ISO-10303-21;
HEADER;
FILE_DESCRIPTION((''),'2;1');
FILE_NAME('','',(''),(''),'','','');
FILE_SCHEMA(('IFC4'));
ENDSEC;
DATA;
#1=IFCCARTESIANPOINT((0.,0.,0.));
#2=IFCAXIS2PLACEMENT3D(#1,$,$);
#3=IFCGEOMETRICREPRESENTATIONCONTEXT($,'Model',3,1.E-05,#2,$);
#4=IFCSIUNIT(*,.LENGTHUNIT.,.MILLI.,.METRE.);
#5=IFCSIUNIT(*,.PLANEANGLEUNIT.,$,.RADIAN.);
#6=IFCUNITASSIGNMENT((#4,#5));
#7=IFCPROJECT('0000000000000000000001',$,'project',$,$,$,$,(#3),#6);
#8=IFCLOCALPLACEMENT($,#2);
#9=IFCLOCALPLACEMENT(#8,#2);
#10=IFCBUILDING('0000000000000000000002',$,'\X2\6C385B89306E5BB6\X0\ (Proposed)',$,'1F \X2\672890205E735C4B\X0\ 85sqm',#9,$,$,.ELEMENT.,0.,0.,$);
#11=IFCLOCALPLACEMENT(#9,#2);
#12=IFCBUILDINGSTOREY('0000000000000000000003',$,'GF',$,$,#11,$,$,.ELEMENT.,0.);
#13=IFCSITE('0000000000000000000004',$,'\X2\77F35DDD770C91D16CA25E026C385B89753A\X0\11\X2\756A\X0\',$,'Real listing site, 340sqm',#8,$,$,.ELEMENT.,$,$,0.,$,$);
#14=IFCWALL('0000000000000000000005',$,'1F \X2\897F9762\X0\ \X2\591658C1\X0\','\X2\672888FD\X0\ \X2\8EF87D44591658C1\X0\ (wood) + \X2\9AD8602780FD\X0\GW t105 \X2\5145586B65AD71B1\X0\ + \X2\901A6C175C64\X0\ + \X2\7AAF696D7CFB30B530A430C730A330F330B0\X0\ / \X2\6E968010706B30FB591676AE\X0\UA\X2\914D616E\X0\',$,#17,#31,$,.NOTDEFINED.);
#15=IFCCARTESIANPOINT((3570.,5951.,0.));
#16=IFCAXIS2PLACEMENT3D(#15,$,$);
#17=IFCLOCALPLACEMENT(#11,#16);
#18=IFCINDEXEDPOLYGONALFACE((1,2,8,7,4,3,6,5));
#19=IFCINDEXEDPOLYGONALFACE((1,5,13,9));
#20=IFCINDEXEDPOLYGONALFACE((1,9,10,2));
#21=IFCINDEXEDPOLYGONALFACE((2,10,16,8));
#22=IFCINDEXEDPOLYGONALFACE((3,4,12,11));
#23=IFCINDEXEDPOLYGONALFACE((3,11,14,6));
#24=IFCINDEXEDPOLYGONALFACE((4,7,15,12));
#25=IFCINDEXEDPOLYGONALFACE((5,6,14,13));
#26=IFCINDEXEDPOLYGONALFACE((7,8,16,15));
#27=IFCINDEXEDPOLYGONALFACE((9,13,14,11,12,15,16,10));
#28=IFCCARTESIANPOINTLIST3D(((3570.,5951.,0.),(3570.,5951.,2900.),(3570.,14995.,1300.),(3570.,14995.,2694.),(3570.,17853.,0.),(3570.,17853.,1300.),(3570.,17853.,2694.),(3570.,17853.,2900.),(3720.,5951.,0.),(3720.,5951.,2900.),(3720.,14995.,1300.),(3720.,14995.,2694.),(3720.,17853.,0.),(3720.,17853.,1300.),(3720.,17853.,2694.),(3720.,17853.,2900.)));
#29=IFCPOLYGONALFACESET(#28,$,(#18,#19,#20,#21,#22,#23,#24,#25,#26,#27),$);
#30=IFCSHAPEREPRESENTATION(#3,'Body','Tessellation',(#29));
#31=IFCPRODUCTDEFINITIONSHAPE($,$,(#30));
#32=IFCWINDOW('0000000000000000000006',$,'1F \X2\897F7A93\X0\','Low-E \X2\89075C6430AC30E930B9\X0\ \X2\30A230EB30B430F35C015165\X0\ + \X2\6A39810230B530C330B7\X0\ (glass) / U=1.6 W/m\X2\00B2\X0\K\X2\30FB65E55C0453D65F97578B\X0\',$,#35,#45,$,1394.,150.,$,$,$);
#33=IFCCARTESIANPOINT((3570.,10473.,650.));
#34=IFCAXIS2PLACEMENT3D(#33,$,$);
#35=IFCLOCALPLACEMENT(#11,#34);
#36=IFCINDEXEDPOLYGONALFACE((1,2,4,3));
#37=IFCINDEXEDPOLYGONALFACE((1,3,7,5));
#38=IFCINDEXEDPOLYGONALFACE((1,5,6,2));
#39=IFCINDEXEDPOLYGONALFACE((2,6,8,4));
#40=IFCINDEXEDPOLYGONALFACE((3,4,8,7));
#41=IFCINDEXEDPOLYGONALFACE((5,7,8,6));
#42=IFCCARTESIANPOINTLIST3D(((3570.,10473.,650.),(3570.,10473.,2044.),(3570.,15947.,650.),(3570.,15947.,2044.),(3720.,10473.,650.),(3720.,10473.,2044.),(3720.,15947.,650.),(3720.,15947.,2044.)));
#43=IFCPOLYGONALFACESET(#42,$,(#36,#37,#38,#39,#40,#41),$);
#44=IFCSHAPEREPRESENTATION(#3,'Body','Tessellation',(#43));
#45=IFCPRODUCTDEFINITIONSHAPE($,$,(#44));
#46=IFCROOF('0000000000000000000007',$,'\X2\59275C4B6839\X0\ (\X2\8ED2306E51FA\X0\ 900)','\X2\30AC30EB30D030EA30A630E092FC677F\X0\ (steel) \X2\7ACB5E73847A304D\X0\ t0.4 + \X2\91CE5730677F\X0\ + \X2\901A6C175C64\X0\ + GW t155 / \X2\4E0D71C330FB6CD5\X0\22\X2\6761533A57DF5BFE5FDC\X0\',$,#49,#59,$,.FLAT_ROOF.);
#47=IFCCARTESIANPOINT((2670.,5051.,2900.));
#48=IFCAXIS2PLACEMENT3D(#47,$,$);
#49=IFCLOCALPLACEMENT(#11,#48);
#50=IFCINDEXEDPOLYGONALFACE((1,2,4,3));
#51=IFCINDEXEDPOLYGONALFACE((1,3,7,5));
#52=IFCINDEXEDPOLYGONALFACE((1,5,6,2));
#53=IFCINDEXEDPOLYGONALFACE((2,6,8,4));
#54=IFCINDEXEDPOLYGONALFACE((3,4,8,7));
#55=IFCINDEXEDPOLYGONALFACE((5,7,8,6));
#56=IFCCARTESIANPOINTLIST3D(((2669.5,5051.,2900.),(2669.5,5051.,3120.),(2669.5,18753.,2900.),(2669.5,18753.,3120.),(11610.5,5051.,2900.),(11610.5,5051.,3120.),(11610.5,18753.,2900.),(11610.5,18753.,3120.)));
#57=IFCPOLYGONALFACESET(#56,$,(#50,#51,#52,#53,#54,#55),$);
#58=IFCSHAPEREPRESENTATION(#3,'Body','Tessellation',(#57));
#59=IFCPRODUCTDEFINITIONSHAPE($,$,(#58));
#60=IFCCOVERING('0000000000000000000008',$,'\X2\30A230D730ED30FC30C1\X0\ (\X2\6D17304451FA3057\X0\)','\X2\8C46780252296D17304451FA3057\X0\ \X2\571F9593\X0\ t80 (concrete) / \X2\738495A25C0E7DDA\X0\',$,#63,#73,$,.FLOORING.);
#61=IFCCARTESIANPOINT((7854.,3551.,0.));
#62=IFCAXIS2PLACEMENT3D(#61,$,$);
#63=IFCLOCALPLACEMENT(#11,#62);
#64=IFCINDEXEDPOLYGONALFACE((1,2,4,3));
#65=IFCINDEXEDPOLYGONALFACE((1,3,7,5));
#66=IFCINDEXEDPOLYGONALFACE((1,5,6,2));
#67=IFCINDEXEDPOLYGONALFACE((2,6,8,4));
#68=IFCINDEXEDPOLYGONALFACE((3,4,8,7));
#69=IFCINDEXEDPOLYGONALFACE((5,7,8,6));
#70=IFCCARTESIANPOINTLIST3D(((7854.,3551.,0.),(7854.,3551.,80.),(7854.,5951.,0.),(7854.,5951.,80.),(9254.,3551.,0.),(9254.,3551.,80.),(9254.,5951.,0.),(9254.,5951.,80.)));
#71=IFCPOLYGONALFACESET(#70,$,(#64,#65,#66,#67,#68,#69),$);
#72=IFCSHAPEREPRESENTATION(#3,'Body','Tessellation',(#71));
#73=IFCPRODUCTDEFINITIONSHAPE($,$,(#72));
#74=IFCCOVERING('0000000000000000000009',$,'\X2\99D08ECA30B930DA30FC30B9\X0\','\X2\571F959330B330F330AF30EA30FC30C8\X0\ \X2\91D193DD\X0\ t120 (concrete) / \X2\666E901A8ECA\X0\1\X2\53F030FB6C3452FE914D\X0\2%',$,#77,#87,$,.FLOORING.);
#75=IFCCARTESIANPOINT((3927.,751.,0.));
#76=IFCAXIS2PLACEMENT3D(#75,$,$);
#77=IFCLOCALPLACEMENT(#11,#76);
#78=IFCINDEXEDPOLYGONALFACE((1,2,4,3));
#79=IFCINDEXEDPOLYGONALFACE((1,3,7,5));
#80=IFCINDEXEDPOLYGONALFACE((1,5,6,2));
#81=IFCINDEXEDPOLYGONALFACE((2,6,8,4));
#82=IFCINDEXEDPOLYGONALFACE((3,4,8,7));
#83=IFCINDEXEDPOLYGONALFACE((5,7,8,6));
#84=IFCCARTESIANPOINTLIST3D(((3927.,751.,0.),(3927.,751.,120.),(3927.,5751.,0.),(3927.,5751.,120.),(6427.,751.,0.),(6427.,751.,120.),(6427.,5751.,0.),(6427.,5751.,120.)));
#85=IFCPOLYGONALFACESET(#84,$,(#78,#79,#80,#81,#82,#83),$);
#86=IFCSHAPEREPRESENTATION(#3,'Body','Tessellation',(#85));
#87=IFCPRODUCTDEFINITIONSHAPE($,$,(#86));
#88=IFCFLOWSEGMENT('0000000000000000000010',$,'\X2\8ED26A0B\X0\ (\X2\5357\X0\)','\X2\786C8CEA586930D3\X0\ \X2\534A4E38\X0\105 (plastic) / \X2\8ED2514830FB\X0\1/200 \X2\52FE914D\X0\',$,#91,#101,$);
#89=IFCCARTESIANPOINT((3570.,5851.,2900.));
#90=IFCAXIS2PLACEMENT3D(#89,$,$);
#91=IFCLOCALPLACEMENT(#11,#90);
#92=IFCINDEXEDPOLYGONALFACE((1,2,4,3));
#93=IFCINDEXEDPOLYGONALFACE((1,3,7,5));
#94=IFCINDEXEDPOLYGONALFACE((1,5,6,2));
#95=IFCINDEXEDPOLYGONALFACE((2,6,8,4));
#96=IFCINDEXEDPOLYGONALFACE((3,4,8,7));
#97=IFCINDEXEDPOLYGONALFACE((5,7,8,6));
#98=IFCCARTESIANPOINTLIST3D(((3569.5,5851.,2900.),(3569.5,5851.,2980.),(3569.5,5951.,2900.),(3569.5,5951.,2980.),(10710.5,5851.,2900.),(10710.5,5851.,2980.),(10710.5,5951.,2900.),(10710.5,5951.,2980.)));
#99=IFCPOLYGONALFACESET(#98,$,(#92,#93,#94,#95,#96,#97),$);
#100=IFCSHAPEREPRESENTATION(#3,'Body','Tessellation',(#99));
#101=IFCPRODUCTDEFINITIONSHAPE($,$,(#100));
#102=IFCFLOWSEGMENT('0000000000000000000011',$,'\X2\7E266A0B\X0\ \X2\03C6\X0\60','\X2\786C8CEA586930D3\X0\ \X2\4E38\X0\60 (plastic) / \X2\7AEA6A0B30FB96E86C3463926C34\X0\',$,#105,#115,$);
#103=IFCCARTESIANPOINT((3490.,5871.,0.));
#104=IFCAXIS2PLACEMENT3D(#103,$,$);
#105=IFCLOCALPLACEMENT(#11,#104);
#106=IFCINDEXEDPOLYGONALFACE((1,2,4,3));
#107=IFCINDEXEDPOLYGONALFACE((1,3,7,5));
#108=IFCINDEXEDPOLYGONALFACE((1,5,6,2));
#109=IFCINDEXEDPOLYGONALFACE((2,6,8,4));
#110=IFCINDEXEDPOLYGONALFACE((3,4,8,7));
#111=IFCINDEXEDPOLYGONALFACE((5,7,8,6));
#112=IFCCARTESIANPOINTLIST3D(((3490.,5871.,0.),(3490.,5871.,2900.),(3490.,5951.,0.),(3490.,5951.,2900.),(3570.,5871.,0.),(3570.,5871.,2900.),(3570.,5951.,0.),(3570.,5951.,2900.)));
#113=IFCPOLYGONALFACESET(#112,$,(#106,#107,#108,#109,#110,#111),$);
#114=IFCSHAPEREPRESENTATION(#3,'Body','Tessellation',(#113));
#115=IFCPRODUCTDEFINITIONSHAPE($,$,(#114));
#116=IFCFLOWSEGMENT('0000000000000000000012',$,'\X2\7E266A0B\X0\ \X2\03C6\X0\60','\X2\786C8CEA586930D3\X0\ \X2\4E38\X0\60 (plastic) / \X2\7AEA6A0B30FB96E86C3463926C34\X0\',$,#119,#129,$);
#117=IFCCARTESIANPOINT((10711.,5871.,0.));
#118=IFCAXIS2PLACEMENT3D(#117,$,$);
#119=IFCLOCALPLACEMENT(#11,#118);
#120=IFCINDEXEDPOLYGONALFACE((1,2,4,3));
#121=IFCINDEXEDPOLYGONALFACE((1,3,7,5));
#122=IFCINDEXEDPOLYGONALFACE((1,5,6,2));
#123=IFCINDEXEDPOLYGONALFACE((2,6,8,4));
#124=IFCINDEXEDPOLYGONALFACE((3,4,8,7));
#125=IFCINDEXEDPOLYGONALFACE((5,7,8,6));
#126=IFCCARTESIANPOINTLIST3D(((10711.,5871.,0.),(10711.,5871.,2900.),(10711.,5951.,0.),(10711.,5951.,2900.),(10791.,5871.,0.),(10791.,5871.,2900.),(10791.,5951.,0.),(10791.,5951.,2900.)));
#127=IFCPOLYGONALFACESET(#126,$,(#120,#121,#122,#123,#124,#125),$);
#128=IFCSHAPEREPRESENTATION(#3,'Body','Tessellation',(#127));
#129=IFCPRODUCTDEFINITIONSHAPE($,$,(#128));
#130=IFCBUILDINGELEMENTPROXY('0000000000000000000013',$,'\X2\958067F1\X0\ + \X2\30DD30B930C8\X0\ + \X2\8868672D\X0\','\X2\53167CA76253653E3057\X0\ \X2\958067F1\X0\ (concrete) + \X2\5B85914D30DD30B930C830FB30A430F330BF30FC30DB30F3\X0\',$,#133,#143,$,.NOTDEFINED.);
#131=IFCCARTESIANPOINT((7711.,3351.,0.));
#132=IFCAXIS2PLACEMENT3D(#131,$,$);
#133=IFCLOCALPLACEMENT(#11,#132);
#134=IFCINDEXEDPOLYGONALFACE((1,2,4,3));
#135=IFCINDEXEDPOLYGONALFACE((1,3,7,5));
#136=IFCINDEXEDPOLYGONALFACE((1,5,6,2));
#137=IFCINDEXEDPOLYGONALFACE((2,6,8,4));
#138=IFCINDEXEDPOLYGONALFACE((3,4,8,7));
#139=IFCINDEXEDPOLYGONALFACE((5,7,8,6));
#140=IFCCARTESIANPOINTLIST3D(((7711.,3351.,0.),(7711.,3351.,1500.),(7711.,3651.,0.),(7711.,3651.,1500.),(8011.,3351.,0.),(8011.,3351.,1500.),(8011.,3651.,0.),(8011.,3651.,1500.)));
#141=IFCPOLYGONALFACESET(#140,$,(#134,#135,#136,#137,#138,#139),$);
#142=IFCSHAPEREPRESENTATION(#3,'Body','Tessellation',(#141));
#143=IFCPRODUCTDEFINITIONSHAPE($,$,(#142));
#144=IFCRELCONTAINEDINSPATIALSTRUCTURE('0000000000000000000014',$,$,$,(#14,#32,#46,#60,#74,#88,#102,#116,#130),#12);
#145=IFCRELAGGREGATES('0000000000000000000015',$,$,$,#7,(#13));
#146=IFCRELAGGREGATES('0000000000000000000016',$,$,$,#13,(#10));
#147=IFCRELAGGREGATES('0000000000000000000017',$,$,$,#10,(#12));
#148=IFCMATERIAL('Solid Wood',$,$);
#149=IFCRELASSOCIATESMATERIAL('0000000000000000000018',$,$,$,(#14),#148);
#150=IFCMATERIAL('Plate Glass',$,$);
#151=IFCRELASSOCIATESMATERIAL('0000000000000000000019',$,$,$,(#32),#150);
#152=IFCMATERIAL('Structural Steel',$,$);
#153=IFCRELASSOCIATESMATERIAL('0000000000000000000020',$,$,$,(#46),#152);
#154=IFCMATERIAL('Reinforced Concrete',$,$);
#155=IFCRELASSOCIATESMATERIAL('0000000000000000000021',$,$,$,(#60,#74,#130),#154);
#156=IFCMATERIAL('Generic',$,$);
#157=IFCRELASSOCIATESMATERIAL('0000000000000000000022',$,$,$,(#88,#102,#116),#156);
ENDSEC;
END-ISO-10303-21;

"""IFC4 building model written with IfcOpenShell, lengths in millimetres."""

from ifc_helpers import new_model, si_unit, frame, frame_2d, origin, place, context, project, spatial, rectangle, extrude, material, element, fill, save


model = new_model("IFC4")

# Units and contexts
model_context = context("Model", 3, precision=1e-05, world=origin())
ifc_project = project(units=[si_unit("LENGTHUNIT", "METRE", prefix="MILLI"), si_unit("PLANEANGLEUNIT", "RADIAN")], contexts=[model_context])

# Site, building, storey
site_placement = place(None, origin())
site = spatial("IfcSite", under=ifc_project, at=site_placement, Name="石川県金沢市永安町11番", ObjectType="Real listing site, 340sqm", CompositionType="ELEMENT", RefElevation=0.0)
building_placement = place(site_placement, origin())
building = spatial("IfcBuilding", under=site, at=building_placement, Name="永安の家 (Proposed)", ObjectType="1F 木造平屋 85sqm", CompositionType="ELEMENT", ElevationOfRefHeight=0.0, ElevationOfTerrain=0.0)
storey_placement = place(building_placement, origin())
storey = spatial("IfcBuildingStorey", under=building, at=storey_placement, Name="GF", CompositionType="ELEMENT", Elevation=0.0)

# Shared definitions
ifc_material_1 = material(Name="Solid Wood")

# Shared definitions
ifc_material_2 = material(Name="Reinforced Concrete")

# Shared definitions
ifc_material_3 = material(Name="Plate Glass")

# Wall, opening, window
wall_1_placement = place(storey_placement, frame((3570.0, 5951.0, 0.0)))
wall_1 = element("IfcWall", 1, at=wall_1_placement, inside=storey, material=ifc_material_1, Name="1F 西面 外壁", Description="木製 軸組外壁 (wood) + 高性能GW t105 充填断熱 + 通気層 + 窯業系サイディング / 準耐火・外皮UA配慮", PredefinedType="NOTDEFINED", context=model_context, shape_type="SweptSolid", body=[
    extrude(rectangle(XDim=150.0, YDim=11902.0, at=frame_2d((75.0, 5951.0))), frame((3570.0, 5951.0, 0.0)), (0.0, 0.0, 1.0), 2900.0),
])
opening_1_placement = place(storey_placement, frame((3570.0, 10473.0, 650.0)))
opening_1 = element("IfcOpeningElement", 2, at=opening_1_placement, cuts=wall_1, PredefinedType="NOTDEFINED", context=model_context, shape_type="SweptSolid", body=[
    extrude(rectangle(XDim=150.0, YDim=5474.0, at=frame_2d((75.0, 2737.0))), frame((3570.0, 10473.0, 650.0)), (0.0, 0.0, 1.0), 1394.0),
])
window_1_placement = place(storey_placement, frame((3570.0, 10473.0, 650.0)))
window_1 = element("IfcWindow", 3, at=window_1_placement, inside=storey, material=ifc_material_3, Name="1F 西窓", Description="Low-E 複層ガラス アルゴン封入 + 樹脂サッシ (glass) / U=1.6 W/m²K・日射取得型", OverallHeight=1394.0, OverallWidth=150.0, context=model_context, shape_type="SweptSolid", body=[
    extrude(rectangle(XDim=150.0, YDim=5474.0, at=frame_2d((75.0, 2737.0))), frame((3570.0, 10473.0, 650.0)), (0.0, 0.0, 1.0), 1394.0),
])
fill(opening_1, window_1)

# Roof
ifc_material_4 = material(Name="Structural Steel")
roof_placement = place(storey_placement, frame((2670.0, 5051.0, 2900.0)))
element("IfcRoof", 4, at=roof_placement, inside=storey, material=ifc_material_4, Name="大屋根 (軒の出 900)", Description="ガルバリウム鋼板 (steel) 立平葺き t0.4 + 野地板 + 通気層 + GW t155 / 不燃・法22条区域対応", PredefinedType="FLAT_ROOF", context=model_context, shape_type="SweptSolid", body=[
    extrude(rectangle(XDim=8941.0, YDim=13702.0, at=frame_2d((4470.0, 6851.0))), frame((2670.0, 5051.0, 2900.0)), (0.0, 0.0, 1.0), 220.0),
])

# Coverings
covering_1_placement = place(storey_placement, frame((7854.0, 3551.0, 0.0)))
element("IfcCovering", 5, at=covering_1_placement, inside=storey, material=ifc_material_2, Name="アプローチ (洗い出し)", Description="豆砂利洗い出し 土間 t80 (concrete) / 玄関導線", PredefinedType="FLOORING", context=model_context, shape_type="SweptSolid", body=[
    extrude(rectangle(XDim=1400.0, YDim=2400.0, at=frame_2d((700.0, 1200.0))), frame((7854.0, 3551.0, 0.0)), (0.0, 0.0, 1.0), 80.0),
])
covering_2_placement = place(storey_placement, frame((3927.0, 751.0, 0.0)))
element("IfcCovering", 6, at=covering_2_placement, inside=storey, material=ifc_material_2, Name="駐車スペース", Description="土間コンクリート 金鏝 t120 (concrete) / 普通車1台・水勾配2%", PredefinedType="FLOORING", context=model_context, shape_type="SweptSolid", body=[
    extrude(rectangle(XDim=2500.0, YDim=5000.0, at=frame_2d((1250.0, 2500.0))), frame((3927.0, 751.0, 0.0)), (0.0, 0.0, 1.0), 120.0),
])

# Flow segments
ifc_material_5 = material(Name="Generic")
flow_segment_1_placement = place(storey_placement, frame((3570.0, 5851.0, 2900.0)))
element("IfcFlowSegment", 7, at=flow_segment_1_placement, inside=storey, material=ifc_material_5, Name="軒樋 (南)", Description="硬質塩ビ 半丸105 (plastic) / 軒先・1/200 勾配", context=model_context, shape_type="SweptSolid", body=[
    extrude(rectangle(XDim=7141.0, YDim=100.0, at=frame_2d((3570.0, 50.0))), frame((3570.0, 5851.0, 2900.0)), (0.0, 0.0, 1.0), 80.0),
])
flow_segment_2_placement = place(storey_placement, frame((3490.0, 5871.0, 0.0)))
element("IfcFlowSegment", 8, at=flow_segment_2_placement, inside=storey, material=ifc_material_5, Name="縦樋 φ60", Description="硬質塩ビ 丸60 (plastic) / 竪樋・雨水排水", context=model_context, shape_type="SweptSolid", body=[
    extrude(rectangle(XDim=80.0, YDim=80.0, at=frame_2d((40.0, 40.0))), frame((3490.0, 5871.0, 0.0)), (0.0, 0.0, 1.0), 2900.0),
])
flow_segment_3_placement = place(storey_placement, frame((10711.0, 5871.0, 0.0)))
element("IfcFlowSegment", 9, at=flow_segment_3_placement, inside=storey, material=ifc_material_5, Name="縦樋 φ60", Description="硬質塩ビ 丸60 (plastic) / 竪樋・雨水排水", context=model_context, shape_type="SweptSolid", body=[
    extrude(rectangle(XDim=80.0, YDim=80.0, at=frame_2d((40.0, 40.0))), frame((10711.0, 5871.0, 0.0)), (0.0, 0.0, 1.0), 2900.0),
])

# Building element proxy
proxy_placement = place(storey_placement, frame((7711.0, 3351.0, 0.0)))
element("IfcBuildingElementProxy", 10, at=proxy_placement, inside=storey, material=ifc_material_2, Name="門柱 + ポスト + 表札", Description="化粧打放し 門柱 (concrete) + 宅配ポスト・インターホン", PredefinedType="NOTDEFINED", context=model_context, shape_type="SweptSolid", body=[
    extrude(rectangle(XDim=300.0, YDim=300.0, at=frame_2d((150.0, 150.0))), frame((7711.0, 3351.0, 0.0)), (0.0, 0.0, 1.0), 1500.0),
])

save(model, "model.ifc")
